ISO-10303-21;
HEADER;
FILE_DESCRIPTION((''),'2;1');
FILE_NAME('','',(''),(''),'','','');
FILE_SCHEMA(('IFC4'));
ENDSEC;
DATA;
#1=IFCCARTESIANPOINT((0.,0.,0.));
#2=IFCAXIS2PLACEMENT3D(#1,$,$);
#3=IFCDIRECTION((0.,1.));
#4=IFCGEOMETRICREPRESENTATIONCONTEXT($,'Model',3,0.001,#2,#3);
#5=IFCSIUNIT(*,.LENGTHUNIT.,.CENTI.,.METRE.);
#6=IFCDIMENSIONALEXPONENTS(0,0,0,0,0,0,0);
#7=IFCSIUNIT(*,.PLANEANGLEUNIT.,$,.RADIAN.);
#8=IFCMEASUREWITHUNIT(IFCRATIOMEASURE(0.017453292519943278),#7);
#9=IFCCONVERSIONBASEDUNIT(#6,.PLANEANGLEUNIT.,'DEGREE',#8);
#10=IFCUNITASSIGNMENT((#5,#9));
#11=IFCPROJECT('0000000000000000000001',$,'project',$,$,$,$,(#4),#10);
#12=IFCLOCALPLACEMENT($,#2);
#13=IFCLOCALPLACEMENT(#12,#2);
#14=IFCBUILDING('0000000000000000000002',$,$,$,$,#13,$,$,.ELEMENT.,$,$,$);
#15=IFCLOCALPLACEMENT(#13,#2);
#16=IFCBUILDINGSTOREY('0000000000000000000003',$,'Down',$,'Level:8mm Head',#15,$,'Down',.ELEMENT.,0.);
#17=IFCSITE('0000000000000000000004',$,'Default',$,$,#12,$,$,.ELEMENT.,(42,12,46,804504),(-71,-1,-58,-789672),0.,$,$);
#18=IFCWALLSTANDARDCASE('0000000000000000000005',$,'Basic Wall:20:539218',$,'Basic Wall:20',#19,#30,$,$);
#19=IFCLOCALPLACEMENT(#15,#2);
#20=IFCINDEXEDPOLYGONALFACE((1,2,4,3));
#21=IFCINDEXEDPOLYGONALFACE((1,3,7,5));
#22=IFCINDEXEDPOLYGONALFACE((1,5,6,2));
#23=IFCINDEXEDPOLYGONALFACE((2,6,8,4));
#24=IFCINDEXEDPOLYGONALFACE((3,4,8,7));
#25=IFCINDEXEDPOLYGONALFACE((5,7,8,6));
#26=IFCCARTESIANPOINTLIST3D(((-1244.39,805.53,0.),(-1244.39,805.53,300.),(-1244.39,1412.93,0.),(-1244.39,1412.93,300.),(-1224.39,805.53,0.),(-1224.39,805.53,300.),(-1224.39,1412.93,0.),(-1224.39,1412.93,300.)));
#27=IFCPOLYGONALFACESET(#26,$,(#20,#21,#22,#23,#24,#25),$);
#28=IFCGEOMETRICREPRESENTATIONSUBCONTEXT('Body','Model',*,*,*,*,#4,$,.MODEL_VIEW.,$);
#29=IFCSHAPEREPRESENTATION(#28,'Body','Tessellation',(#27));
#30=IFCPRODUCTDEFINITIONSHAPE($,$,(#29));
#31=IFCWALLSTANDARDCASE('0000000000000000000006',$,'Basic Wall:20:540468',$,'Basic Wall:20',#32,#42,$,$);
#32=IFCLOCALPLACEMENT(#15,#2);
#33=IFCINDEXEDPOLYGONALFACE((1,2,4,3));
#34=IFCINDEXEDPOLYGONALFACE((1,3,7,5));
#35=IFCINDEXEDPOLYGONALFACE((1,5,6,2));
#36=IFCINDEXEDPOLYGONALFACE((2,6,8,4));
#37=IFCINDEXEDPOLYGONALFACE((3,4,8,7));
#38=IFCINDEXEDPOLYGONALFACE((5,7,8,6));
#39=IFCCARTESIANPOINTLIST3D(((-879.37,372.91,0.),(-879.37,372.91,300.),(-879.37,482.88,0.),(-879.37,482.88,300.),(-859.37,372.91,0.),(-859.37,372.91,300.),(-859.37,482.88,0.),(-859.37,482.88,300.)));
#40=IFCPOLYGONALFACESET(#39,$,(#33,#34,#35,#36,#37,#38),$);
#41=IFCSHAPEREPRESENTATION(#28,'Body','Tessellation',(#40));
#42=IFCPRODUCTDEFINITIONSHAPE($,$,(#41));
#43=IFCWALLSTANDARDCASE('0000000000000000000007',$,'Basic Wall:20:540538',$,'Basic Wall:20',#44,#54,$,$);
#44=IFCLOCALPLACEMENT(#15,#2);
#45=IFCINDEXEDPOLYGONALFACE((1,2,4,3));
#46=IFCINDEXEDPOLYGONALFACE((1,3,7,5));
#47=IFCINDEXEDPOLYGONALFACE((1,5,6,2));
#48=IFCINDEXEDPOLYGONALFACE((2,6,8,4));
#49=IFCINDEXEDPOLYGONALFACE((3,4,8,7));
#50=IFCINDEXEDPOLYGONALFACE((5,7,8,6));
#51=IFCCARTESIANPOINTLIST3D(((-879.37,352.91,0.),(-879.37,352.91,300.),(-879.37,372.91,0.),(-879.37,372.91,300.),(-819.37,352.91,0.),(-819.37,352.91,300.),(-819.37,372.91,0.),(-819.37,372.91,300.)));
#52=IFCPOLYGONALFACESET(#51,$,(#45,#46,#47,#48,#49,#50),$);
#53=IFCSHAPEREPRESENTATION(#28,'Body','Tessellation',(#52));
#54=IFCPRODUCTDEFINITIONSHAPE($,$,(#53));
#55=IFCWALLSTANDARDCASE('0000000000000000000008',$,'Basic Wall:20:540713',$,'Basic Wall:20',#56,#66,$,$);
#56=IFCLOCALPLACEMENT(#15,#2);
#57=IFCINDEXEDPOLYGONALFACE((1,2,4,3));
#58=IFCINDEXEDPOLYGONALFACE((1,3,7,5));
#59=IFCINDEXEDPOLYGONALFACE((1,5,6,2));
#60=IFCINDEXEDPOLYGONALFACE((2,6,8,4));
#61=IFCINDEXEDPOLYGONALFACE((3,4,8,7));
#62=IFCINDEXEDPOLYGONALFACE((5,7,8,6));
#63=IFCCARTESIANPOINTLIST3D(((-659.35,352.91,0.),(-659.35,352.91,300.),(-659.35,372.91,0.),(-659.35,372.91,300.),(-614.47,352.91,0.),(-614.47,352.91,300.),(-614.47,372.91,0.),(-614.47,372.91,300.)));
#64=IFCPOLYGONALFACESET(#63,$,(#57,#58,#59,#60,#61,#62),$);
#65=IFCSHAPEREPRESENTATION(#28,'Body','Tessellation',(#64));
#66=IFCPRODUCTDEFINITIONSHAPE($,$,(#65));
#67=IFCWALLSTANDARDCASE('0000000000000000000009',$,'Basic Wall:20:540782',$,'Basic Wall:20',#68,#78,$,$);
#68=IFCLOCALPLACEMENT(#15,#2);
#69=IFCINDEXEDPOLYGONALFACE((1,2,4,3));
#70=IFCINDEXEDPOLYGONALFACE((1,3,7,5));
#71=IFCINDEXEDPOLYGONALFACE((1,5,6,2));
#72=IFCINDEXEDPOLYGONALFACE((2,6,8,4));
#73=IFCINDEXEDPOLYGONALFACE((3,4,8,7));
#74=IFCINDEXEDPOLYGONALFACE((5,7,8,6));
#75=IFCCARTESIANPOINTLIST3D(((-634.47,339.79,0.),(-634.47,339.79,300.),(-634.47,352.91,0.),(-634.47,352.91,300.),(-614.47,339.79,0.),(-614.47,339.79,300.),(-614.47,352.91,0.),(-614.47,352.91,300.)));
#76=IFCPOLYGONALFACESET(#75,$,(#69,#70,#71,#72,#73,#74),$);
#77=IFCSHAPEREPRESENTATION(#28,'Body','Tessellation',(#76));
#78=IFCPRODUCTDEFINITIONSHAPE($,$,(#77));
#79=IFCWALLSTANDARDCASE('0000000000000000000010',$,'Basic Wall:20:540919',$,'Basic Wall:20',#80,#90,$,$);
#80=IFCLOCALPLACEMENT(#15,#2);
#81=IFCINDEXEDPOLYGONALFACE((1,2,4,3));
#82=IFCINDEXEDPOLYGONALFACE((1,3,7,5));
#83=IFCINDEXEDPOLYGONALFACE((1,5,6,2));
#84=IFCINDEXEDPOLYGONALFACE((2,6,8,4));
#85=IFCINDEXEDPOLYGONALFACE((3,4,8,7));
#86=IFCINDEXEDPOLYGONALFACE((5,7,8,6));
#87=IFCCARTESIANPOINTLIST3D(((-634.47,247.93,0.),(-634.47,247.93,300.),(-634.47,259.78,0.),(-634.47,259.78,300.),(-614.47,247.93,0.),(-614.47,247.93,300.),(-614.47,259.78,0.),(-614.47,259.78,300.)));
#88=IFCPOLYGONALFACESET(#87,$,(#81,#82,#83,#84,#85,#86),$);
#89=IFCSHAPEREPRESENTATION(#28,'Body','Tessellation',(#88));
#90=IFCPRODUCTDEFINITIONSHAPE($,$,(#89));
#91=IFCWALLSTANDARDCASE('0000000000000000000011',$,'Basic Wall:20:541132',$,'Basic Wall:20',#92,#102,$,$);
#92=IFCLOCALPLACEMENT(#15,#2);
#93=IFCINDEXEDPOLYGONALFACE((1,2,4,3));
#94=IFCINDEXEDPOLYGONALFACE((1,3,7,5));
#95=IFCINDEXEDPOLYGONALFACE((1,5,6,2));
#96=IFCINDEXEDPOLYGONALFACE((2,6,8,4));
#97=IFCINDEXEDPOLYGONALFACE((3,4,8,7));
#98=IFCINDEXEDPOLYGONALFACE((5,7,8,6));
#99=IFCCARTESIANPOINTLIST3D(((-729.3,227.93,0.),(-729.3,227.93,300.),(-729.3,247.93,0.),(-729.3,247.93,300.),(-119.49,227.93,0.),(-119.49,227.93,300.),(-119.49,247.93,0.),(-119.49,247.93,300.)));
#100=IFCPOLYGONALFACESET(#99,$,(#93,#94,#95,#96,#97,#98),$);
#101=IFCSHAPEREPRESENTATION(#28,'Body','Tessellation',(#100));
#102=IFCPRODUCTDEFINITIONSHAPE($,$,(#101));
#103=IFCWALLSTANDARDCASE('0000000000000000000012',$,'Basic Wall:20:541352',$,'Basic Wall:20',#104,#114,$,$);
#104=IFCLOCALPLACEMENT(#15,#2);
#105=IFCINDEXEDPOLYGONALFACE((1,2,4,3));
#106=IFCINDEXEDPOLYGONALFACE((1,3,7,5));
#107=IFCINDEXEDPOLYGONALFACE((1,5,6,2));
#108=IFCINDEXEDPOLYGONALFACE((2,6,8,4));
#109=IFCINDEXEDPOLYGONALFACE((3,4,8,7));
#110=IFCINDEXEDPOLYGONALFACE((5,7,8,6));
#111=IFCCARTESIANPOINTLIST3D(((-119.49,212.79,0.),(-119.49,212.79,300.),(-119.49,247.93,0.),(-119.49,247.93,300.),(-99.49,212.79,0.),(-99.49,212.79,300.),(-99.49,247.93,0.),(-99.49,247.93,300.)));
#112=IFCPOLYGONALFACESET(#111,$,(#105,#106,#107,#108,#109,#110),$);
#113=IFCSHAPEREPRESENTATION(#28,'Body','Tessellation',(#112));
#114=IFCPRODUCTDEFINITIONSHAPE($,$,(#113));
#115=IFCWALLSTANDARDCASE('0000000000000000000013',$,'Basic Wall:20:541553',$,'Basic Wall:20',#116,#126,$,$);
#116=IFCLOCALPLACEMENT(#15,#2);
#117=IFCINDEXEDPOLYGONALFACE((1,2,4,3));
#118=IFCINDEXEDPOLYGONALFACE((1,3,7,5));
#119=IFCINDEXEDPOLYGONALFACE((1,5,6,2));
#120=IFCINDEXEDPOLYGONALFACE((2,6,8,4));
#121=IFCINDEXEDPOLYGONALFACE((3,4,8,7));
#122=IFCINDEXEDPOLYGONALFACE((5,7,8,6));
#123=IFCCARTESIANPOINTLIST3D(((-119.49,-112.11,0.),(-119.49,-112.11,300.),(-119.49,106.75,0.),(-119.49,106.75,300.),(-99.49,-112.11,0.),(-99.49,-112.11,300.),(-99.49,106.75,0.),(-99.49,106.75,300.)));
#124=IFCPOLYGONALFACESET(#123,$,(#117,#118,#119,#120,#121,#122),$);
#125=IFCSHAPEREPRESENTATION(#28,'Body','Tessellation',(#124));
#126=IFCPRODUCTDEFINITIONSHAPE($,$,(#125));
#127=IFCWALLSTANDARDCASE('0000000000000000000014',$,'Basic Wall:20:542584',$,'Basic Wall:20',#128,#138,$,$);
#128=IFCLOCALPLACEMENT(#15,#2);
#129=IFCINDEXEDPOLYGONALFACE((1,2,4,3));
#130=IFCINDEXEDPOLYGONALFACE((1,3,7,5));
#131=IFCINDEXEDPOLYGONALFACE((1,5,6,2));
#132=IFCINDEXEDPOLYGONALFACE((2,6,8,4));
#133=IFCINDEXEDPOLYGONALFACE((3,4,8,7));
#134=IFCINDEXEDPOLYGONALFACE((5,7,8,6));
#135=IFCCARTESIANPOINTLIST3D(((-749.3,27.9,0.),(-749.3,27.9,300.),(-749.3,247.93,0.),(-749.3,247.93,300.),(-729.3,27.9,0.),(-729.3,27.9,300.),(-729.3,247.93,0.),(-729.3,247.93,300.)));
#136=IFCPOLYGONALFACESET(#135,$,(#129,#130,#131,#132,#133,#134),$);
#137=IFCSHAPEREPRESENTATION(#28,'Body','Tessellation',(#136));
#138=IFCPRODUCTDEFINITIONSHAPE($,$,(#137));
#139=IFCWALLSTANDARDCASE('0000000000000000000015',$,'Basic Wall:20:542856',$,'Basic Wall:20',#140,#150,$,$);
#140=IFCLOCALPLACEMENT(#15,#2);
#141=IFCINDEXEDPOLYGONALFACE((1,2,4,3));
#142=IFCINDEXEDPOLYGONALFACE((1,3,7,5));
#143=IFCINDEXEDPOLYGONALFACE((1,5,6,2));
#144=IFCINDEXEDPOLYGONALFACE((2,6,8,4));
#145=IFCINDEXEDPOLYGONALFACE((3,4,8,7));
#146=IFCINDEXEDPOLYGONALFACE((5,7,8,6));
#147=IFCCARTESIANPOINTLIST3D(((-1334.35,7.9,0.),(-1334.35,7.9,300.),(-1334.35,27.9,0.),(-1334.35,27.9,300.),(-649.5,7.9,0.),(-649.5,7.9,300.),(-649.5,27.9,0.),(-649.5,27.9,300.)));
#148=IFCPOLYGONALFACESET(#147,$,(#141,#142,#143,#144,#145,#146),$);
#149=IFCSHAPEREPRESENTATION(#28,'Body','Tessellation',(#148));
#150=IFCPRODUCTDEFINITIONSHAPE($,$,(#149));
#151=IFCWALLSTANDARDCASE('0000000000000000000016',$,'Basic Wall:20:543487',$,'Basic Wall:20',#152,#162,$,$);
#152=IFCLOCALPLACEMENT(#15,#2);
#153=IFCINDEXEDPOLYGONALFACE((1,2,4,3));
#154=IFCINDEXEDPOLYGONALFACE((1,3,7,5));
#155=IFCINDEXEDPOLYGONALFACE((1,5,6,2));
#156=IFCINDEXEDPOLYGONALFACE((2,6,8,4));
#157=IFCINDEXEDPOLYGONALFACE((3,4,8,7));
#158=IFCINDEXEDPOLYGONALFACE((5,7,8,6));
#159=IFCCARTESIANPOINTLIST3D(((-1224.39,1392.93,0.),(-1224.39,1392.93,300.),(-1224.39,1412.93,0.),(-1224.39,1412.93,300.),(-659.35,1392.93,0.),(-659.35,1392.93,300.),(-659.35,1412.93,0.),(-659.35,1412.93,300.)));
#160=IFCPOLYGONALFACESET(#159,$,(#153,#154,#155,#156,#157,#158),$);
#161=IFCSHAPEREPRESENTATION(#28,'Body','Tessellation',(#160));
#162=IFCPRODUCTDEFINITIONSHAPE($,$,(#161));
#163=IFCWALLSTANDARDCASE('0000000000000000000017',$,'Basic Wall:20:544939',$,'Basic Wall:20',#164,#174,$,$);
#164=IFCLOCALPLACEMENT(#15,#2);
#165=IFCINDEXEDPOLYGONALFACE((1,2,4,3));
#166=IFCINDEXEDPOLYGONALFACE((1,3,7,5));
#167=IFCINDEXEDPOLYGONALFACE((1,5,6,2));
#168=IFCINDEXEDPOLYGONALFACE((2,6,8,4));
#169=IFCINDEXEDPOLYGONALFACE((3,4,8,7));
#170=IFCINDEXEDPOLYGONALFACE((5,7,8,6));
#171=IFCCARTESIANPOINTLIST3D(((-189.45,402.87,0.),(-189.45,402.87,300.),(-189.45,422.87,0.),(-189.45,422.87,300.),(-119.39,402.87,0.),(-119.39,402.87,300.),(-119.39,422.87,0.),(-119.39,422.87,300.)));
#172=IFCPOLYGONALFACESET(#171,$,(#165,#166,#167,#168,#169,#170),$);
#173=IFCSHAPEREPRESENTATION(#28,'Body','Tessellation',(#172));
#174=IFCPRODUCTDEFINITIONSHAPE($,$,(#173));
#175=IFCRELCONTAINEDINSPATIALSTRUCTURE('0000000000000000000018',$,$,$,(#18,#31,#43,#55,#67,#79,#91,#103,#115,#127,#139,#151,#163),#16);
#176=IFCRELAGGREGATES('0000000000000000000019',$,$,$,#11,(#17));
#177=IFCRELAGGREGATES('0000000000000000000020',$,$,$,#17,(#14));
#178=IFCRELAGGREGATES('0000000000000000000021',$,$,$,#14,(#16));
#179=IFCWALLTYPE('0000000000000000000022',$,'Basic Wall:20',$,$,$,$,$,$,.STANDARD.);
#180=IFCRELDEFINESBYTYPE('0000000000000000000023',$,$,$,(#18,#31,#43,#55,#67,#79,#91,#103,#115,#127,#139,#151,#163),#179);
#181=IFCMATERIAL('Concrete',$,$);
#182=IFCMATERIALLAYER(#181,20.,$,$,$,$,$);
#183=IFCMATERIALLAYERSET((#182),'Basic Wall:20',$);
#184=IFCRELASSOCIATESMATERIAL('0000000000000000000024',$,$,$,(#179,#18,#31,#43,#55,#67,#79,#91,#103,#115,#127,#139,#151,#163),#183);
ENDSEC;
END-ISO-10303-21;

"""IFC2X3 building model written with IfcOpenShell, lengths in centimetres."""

from ifc_helpers import new_model, entity, si_unit, converted_unit, direction, frame, frame_2d, origin, place, context, subcontext, project, spatial, rectangle, extrude, material, layer, layer_set, layer_usage, type_object, element, save


model = new_model("IFC2X3")

# Units and contexts
model_context = context("Model", 3, precision=0.001, world=origin(), true_north=direction((0.0, 1.0)))
body_context = subcontext(model_context, "Body", "Model", "MODEL_VIEW")
ifc_project = project(units=[si_unit("LENGTHUNIT", "METRE", prefix="CENTI"), converted_unit("PLANEANGLEUNIT", "DEGREE", entity("IfcRatioMeasure", 0.017453292519943278), si_unit("PLANEANGLEUNIT", "RADIAN"), dimensions=[0, 0, 0, 0, 0, 0, 0])], contexts=[model_context])

# Site, building, storey
site_placement = place(None, origin())
site = spatial("IfcSite", under=ifc_project, at=site_placement, Name="Default", CompositionType="ELEMENT", RefLatitude=(42, 12, 46, 804504), RefLongitude=(-71, -1, -58, -789672), RefElevation=0.0)
building_placement = place(site_placement, origin())
building = spatial("IfcBuilding", under=site, at=building_placement, CompositionType="ELEMENT")
storey_placement = place(building_placement, origin())
storey = spatial("IfcBuildingStorey", under=building, at=storey_placement, Name="Down", ObjectType="Level:8mm Head", LongName="Down", CompositionType="ELEMENT", Elevation=0.0)

# Walls
ifc_material = material(Name="Concrete")
ifc_layer_1 = layer(ifc_material, 20.0)
ifc_layer_set_1 = layer_set([ifc_layer_1], Name="Basic Wall:20")
ifc_layer_usage_1 = layer_usage(ifc_layer_set_1, "AXIS2", "POSITIVE", -10.0)
wall_type_1 = type_object("IfcWallType", Name="Basic Wall:20", PredefinedType="STANDARD", material=ifc_layer_set_1)
wall_1_placement = place(storey_placement, frame((-1234.39, 1412.93, 0.0), z_axis=(0.0, 0.0, 1.0), x_axis=(0.0, -1.0, 0.0)))
element("IfcWallStandardCase", 1, at=wall_1_placement, inside=storey, type_object=wall_type_1, material=ifc_layer_usage_1, Name="Basic Wall:20:539218", ObjectType="Basic Wall:20", context=body_context, shape_type="SweptSolid", body=[
    extrude(rectangle(XDim=607.41, YDim=20.0, at=frame_2d((303.7, 0.0), x_axis=(-1.0, 0.0))), origin(), (0.0, 0.0, 1.0), 300.0),
])
ifc_layer_usage_2 = layer_usage(ifc_layer_set_1, "AXIS2", "NEGATIVE", 10.0)
wall_2_placement = place(storey_placement, frame((-869.37, 482.88, 0.0), z_axis=(0.0, 0.0, 1.0), x_axis=(0.0, -1.0, 0.0)))
element("IfcWallStandardCase", 2, at=wall_2_placement, inside=storey, type_object=wall_type_1, material=ifc_layer_usage_2, Name="Basic Wall:20:540468", ObjectType="Basic Wall:20", context=body_context, shape_type="SweptSolid", body=[
    extrude(rectangle(XDim=109.96, YDim=20.0, at=frame_2d((54.98, 0.0), x_axis=(-1.0, 0.0))), origin(), (0.0, 0.0, 1.0), 300.0),
])
ifc_layer_usage_3 = layer_usage(ifc_layer_set_1, "AXIS2", "POSITIVE", -10.0)
wall_3_placement = place(storey_placement, frame((-879.37, 362.91, 0.0)))
element("IfcWallStandardCase", 3, at=wall_3_placement, inside=storey, type_object=wall_type_1, material=ifc_layer_usage_3, Name="Basic Wall:20:540538", ObjectType="Basic Wall:20", context=body_context, shape_type="SweptSolid", body=[
    extrude(rectangle(XDim=60.0, YDim=20.0, at=frame_2d((30.0, 0.0), x_axis=(-1.0, 0.0))), origin(), (0.0, 0.0, 1.0), 300.0),
])
ifc_layer_usage_4 = layer_usage(ifc_layer_set_1, "AXIS2", "POSITIVE", -10.0)
wall_4_placement = place(storey_placement, frame((-659.35, 362.91, 0.0)))
element("IfcWallStandardCase", 4, at=wall_4_placement, inside=storey, type_object=wall_type_1, material=ifc_layer_usage_4, Name="Basic Wall:20:540713", ObjectType="Basic Wall:20", context=body_context, shape_type="SweptSolid", body=[
    extrude(rectangle(XDim=44.87, YDim=20.0, at=frame_2d((22.44, 0.0), x_axis=(-1.0, 0.0))), origin(), (0.0, 0.0, 1.0), 300.0),
])
ifc_layer_usage_5 = layer_usage(ifc_layer_set_1, "AXIS2", "NEGATIVE", 10.0)
wall_5_placement = place(storey_placement, frame((-624.47, 352.91, 0.0), z_axis=(0.0, 0.0, 1.0), x_axis=(0.0, -1.0, 0.0)))
element("IfcWallStandardCase", 5, at=wall_5_placement, inside=storey, type_object=wall_type_1, material=ifc_layer_usage_5, Name="Basic Wall:20:540782", ObjectType="Basic Wall:20", context=body_context, shape_type="SweptSolid", body=[
    extrude(rectangle(XDim=13.12, YDim=20.0, at=frame_2d((6.56, 0.0), x_axis=(-1.0, 0.0))), origin(), (0.0, 0.0, 1.0), 300.0),
])
ifc_layer_usage_6 = layer_usage(ifc_layer_set_1, "AXIS2", "NEGATIVE", 10.0)
wall_6_placement = place(storey_placement, frame((-624.47, 259.78, 0.0), z_axis=(0.0, 0.0, 1.0), x_axis=(0.0, -1.0, 0.0)))
element("IfcWallStandardCase", 6, at=wall_6_placement, inside=storey, type_object=wall_type_1, material=ifc_layer_usage_6, Name="Basic Wall:20:540919", ObjectType="Basic Wall:20", context=body_context, shape_type="SweptSolid", body=[
    extrude(rectangle(XDim=11.85, YDim=20.0, at=frame_2d((5.93, 0.0), x_axis=(-1.0, 0.0))), origin(), (0.0, 0.0, 1.0), 300.0),
])
ifc_layer_usage_7 = layer_usage(ifc_layer_set_1, "AXIS2", "NEGATIVE", 10.0)
wall_7_placement = place(storey_placement, frame((-729.3, 237.93, 0.0)))
element("IfcWallStandardCase", 7, at=wall_7_placement, inside=storey, type_object=wall_type_1, material=ifc_layer_usage_7, Name="Basic Wall:20:541132", ObjectType="Basic Wall:20", context=body_context, shape_type="SweptSolid", body=[
    extrude(rectangle(XDim=609.81, YDim=20.0, at=frame_2d((304.91, 0.0), x_axis=(-1.0, 0.0))), origin(), (0.0, 0.0, 1.0), 300.0),
])
ifc_layer_usage_8 = layer_usage(ifc_layer_set_1, "AXIS2", "NEGATIVE", 10.0)
wall_8_placement = place(storey_placement, frame((-109.49, 247.93, 0.0), z_axis=(0.0, 0.0, 1.0), x_axis=(0.0, -1.0, 0.0)))
element("IfcWallStandardCase", 8, at=wall_8_placement, inside=storey, type_object=wall_type_1, material=ifc_layer_usage_8, Name="Basic Wall:20:541352", ObjectType="Basic Wall:20", context=body_context, shape_type="SweptSolid", body=[
    extrude(rectangle(XDim=35.14, YDim=20.0, at=frame_2d((17.57, 0.0), x_axis=(-1.0, 0.0))), origin(), (0.0, 0.0, 1.0), 300.0),
])
ifc_layer_usage_9 = layer_usage(ifc_layer_set_1, "AXIS2", "NEGATIVE", 10.0)
wall_9_placement = place(storey_placement, frame((-109.49, 106.75, 0.0), z_axis=(0.0, 0.0, 1.0), x_axis=(0.0, -1.0, 0.0)))
element("IfcWallStandardCase", 9, at=wall_9_placement, inside=storey, type_object=wall_type_1, material=ifc_layer_usage_9, Name="Basic Wall:20:541553", ObjectType="Basic Wall:20", context=body_context, shape_type="SweptSolid", body=[
    extrude(rectangle(XDim=218.86, YDim=20.0, at=frame_2d((109.43, 0.0), x_axis=(-1.0, 0.0))), origin(), (0.0, 0.0, 1.0), 300.0),
])
ifc_layer_usage_10 = layer_usage(ifc_layer_set_1, "AXIS2", "POSITIVE", -10.0)
wall_10_placement = place(storey_placement, frame((-739.3, 247.93, 0.0), z_axis=(0.0, 0.0, 1.0), x_axis=(0.0, -1.0, 0.0)))
element("IfcWallStandardCase", 10, at=wall_10_placement, inside=storey, type_object=wall_type_1, material=ifc_layer_usage_10, Name="Basic Wall:20:542584", ObjectType="Basic Wall:20", context=body_context, shape_type="SweptSolid", body=[
    extrude(rectangle(XDim=220.03, YDim=20.0, at=frame_2d((110.01, 0.0), x_axis=(-1.0, 0.0))), origin(), (0.0, 0.0, 1.0), 300.0),
])
ifc_layer_usage_11 = layer_usage(ifc_layer_set_1, "AXIS2", "NEGATIVE", 10.0)
wall_11_placement = place(storey_placement, frame((-649.5, 17.9, 0.0), z_axis=(0.0, 0.0, 1.0), x_axis=(-1.0, 0.0, 0.0)))
element("IfcWallStandardCase", 11, at=wall_11_placement, inside=storey, type_object=wall_type_1, material=ifc_layer_usage_11, Name="Basic Wall:20:542856", ObjectType="Basic Wall:20", context=body_context, shape_type="SweptSolid", body=[
    extrude(rectangle(XDim=684.84, YDim=20.0, at=frame_2d((342.42, 0.0), x_axis=(-1.0, 0.0))), origin(), (0.0, 0.0, 1.0), 300.0),
])
ifc_layer_usage_12 = layer_usage(ifc_layer_set_1, "AXIS2", "NEGATIVE", 10.0)
wall_12_placement = place(storey_placement, frame((-1224.39, 1402.93, 0.0)))
element("IfcWallStandardCase", 12, at=wall_12_placement, inside=storey, type_object=wall_type_1, material=ifc_layer_usage_12, Name="Basic Wall:20:543487", ObjectType="Basic Wall:20", context=body_context, shape_type="SweptSolid", body=[
    extrude(rectangle(XDim=565.04, YDim=20.0, at=frame_2d((282.52, 0.0), x_axis=(-1.0, 0.0))), origin(), (0.0, 0.0, 1.0), 300.0),
])
ifc_layer_usage_13 = layer_usage(ifc_layer_set_1, "AXIS2", "NEGATIVE", 10.0)
wall_13_placement = place(storey_placement, frame((-119.39, 412.87, 0.0), z_axis=(0.0, 0.0, 1.0), x_axis=(-1.0, 0.0, 0.0)))
element("IfcWallStandardCase", 13, at=wall_13_placement, inside=storey, type_object=wall_type_1, material=ifc_layer_usage_13, Name="Basic Wall:20:544939", ObjectType="Basic Wall:20", context=body_context, shape_type="SweptSolid", body=[
    extrude(rectangle(XDim=70.06, YDim=20.0, at=frame_2d((35.03, 0.0), x_axis=(-1.0, 0.0))), origin(), (0.0, 0.0, 1.0), 300.0),
])

save(model, "model.ifc")
